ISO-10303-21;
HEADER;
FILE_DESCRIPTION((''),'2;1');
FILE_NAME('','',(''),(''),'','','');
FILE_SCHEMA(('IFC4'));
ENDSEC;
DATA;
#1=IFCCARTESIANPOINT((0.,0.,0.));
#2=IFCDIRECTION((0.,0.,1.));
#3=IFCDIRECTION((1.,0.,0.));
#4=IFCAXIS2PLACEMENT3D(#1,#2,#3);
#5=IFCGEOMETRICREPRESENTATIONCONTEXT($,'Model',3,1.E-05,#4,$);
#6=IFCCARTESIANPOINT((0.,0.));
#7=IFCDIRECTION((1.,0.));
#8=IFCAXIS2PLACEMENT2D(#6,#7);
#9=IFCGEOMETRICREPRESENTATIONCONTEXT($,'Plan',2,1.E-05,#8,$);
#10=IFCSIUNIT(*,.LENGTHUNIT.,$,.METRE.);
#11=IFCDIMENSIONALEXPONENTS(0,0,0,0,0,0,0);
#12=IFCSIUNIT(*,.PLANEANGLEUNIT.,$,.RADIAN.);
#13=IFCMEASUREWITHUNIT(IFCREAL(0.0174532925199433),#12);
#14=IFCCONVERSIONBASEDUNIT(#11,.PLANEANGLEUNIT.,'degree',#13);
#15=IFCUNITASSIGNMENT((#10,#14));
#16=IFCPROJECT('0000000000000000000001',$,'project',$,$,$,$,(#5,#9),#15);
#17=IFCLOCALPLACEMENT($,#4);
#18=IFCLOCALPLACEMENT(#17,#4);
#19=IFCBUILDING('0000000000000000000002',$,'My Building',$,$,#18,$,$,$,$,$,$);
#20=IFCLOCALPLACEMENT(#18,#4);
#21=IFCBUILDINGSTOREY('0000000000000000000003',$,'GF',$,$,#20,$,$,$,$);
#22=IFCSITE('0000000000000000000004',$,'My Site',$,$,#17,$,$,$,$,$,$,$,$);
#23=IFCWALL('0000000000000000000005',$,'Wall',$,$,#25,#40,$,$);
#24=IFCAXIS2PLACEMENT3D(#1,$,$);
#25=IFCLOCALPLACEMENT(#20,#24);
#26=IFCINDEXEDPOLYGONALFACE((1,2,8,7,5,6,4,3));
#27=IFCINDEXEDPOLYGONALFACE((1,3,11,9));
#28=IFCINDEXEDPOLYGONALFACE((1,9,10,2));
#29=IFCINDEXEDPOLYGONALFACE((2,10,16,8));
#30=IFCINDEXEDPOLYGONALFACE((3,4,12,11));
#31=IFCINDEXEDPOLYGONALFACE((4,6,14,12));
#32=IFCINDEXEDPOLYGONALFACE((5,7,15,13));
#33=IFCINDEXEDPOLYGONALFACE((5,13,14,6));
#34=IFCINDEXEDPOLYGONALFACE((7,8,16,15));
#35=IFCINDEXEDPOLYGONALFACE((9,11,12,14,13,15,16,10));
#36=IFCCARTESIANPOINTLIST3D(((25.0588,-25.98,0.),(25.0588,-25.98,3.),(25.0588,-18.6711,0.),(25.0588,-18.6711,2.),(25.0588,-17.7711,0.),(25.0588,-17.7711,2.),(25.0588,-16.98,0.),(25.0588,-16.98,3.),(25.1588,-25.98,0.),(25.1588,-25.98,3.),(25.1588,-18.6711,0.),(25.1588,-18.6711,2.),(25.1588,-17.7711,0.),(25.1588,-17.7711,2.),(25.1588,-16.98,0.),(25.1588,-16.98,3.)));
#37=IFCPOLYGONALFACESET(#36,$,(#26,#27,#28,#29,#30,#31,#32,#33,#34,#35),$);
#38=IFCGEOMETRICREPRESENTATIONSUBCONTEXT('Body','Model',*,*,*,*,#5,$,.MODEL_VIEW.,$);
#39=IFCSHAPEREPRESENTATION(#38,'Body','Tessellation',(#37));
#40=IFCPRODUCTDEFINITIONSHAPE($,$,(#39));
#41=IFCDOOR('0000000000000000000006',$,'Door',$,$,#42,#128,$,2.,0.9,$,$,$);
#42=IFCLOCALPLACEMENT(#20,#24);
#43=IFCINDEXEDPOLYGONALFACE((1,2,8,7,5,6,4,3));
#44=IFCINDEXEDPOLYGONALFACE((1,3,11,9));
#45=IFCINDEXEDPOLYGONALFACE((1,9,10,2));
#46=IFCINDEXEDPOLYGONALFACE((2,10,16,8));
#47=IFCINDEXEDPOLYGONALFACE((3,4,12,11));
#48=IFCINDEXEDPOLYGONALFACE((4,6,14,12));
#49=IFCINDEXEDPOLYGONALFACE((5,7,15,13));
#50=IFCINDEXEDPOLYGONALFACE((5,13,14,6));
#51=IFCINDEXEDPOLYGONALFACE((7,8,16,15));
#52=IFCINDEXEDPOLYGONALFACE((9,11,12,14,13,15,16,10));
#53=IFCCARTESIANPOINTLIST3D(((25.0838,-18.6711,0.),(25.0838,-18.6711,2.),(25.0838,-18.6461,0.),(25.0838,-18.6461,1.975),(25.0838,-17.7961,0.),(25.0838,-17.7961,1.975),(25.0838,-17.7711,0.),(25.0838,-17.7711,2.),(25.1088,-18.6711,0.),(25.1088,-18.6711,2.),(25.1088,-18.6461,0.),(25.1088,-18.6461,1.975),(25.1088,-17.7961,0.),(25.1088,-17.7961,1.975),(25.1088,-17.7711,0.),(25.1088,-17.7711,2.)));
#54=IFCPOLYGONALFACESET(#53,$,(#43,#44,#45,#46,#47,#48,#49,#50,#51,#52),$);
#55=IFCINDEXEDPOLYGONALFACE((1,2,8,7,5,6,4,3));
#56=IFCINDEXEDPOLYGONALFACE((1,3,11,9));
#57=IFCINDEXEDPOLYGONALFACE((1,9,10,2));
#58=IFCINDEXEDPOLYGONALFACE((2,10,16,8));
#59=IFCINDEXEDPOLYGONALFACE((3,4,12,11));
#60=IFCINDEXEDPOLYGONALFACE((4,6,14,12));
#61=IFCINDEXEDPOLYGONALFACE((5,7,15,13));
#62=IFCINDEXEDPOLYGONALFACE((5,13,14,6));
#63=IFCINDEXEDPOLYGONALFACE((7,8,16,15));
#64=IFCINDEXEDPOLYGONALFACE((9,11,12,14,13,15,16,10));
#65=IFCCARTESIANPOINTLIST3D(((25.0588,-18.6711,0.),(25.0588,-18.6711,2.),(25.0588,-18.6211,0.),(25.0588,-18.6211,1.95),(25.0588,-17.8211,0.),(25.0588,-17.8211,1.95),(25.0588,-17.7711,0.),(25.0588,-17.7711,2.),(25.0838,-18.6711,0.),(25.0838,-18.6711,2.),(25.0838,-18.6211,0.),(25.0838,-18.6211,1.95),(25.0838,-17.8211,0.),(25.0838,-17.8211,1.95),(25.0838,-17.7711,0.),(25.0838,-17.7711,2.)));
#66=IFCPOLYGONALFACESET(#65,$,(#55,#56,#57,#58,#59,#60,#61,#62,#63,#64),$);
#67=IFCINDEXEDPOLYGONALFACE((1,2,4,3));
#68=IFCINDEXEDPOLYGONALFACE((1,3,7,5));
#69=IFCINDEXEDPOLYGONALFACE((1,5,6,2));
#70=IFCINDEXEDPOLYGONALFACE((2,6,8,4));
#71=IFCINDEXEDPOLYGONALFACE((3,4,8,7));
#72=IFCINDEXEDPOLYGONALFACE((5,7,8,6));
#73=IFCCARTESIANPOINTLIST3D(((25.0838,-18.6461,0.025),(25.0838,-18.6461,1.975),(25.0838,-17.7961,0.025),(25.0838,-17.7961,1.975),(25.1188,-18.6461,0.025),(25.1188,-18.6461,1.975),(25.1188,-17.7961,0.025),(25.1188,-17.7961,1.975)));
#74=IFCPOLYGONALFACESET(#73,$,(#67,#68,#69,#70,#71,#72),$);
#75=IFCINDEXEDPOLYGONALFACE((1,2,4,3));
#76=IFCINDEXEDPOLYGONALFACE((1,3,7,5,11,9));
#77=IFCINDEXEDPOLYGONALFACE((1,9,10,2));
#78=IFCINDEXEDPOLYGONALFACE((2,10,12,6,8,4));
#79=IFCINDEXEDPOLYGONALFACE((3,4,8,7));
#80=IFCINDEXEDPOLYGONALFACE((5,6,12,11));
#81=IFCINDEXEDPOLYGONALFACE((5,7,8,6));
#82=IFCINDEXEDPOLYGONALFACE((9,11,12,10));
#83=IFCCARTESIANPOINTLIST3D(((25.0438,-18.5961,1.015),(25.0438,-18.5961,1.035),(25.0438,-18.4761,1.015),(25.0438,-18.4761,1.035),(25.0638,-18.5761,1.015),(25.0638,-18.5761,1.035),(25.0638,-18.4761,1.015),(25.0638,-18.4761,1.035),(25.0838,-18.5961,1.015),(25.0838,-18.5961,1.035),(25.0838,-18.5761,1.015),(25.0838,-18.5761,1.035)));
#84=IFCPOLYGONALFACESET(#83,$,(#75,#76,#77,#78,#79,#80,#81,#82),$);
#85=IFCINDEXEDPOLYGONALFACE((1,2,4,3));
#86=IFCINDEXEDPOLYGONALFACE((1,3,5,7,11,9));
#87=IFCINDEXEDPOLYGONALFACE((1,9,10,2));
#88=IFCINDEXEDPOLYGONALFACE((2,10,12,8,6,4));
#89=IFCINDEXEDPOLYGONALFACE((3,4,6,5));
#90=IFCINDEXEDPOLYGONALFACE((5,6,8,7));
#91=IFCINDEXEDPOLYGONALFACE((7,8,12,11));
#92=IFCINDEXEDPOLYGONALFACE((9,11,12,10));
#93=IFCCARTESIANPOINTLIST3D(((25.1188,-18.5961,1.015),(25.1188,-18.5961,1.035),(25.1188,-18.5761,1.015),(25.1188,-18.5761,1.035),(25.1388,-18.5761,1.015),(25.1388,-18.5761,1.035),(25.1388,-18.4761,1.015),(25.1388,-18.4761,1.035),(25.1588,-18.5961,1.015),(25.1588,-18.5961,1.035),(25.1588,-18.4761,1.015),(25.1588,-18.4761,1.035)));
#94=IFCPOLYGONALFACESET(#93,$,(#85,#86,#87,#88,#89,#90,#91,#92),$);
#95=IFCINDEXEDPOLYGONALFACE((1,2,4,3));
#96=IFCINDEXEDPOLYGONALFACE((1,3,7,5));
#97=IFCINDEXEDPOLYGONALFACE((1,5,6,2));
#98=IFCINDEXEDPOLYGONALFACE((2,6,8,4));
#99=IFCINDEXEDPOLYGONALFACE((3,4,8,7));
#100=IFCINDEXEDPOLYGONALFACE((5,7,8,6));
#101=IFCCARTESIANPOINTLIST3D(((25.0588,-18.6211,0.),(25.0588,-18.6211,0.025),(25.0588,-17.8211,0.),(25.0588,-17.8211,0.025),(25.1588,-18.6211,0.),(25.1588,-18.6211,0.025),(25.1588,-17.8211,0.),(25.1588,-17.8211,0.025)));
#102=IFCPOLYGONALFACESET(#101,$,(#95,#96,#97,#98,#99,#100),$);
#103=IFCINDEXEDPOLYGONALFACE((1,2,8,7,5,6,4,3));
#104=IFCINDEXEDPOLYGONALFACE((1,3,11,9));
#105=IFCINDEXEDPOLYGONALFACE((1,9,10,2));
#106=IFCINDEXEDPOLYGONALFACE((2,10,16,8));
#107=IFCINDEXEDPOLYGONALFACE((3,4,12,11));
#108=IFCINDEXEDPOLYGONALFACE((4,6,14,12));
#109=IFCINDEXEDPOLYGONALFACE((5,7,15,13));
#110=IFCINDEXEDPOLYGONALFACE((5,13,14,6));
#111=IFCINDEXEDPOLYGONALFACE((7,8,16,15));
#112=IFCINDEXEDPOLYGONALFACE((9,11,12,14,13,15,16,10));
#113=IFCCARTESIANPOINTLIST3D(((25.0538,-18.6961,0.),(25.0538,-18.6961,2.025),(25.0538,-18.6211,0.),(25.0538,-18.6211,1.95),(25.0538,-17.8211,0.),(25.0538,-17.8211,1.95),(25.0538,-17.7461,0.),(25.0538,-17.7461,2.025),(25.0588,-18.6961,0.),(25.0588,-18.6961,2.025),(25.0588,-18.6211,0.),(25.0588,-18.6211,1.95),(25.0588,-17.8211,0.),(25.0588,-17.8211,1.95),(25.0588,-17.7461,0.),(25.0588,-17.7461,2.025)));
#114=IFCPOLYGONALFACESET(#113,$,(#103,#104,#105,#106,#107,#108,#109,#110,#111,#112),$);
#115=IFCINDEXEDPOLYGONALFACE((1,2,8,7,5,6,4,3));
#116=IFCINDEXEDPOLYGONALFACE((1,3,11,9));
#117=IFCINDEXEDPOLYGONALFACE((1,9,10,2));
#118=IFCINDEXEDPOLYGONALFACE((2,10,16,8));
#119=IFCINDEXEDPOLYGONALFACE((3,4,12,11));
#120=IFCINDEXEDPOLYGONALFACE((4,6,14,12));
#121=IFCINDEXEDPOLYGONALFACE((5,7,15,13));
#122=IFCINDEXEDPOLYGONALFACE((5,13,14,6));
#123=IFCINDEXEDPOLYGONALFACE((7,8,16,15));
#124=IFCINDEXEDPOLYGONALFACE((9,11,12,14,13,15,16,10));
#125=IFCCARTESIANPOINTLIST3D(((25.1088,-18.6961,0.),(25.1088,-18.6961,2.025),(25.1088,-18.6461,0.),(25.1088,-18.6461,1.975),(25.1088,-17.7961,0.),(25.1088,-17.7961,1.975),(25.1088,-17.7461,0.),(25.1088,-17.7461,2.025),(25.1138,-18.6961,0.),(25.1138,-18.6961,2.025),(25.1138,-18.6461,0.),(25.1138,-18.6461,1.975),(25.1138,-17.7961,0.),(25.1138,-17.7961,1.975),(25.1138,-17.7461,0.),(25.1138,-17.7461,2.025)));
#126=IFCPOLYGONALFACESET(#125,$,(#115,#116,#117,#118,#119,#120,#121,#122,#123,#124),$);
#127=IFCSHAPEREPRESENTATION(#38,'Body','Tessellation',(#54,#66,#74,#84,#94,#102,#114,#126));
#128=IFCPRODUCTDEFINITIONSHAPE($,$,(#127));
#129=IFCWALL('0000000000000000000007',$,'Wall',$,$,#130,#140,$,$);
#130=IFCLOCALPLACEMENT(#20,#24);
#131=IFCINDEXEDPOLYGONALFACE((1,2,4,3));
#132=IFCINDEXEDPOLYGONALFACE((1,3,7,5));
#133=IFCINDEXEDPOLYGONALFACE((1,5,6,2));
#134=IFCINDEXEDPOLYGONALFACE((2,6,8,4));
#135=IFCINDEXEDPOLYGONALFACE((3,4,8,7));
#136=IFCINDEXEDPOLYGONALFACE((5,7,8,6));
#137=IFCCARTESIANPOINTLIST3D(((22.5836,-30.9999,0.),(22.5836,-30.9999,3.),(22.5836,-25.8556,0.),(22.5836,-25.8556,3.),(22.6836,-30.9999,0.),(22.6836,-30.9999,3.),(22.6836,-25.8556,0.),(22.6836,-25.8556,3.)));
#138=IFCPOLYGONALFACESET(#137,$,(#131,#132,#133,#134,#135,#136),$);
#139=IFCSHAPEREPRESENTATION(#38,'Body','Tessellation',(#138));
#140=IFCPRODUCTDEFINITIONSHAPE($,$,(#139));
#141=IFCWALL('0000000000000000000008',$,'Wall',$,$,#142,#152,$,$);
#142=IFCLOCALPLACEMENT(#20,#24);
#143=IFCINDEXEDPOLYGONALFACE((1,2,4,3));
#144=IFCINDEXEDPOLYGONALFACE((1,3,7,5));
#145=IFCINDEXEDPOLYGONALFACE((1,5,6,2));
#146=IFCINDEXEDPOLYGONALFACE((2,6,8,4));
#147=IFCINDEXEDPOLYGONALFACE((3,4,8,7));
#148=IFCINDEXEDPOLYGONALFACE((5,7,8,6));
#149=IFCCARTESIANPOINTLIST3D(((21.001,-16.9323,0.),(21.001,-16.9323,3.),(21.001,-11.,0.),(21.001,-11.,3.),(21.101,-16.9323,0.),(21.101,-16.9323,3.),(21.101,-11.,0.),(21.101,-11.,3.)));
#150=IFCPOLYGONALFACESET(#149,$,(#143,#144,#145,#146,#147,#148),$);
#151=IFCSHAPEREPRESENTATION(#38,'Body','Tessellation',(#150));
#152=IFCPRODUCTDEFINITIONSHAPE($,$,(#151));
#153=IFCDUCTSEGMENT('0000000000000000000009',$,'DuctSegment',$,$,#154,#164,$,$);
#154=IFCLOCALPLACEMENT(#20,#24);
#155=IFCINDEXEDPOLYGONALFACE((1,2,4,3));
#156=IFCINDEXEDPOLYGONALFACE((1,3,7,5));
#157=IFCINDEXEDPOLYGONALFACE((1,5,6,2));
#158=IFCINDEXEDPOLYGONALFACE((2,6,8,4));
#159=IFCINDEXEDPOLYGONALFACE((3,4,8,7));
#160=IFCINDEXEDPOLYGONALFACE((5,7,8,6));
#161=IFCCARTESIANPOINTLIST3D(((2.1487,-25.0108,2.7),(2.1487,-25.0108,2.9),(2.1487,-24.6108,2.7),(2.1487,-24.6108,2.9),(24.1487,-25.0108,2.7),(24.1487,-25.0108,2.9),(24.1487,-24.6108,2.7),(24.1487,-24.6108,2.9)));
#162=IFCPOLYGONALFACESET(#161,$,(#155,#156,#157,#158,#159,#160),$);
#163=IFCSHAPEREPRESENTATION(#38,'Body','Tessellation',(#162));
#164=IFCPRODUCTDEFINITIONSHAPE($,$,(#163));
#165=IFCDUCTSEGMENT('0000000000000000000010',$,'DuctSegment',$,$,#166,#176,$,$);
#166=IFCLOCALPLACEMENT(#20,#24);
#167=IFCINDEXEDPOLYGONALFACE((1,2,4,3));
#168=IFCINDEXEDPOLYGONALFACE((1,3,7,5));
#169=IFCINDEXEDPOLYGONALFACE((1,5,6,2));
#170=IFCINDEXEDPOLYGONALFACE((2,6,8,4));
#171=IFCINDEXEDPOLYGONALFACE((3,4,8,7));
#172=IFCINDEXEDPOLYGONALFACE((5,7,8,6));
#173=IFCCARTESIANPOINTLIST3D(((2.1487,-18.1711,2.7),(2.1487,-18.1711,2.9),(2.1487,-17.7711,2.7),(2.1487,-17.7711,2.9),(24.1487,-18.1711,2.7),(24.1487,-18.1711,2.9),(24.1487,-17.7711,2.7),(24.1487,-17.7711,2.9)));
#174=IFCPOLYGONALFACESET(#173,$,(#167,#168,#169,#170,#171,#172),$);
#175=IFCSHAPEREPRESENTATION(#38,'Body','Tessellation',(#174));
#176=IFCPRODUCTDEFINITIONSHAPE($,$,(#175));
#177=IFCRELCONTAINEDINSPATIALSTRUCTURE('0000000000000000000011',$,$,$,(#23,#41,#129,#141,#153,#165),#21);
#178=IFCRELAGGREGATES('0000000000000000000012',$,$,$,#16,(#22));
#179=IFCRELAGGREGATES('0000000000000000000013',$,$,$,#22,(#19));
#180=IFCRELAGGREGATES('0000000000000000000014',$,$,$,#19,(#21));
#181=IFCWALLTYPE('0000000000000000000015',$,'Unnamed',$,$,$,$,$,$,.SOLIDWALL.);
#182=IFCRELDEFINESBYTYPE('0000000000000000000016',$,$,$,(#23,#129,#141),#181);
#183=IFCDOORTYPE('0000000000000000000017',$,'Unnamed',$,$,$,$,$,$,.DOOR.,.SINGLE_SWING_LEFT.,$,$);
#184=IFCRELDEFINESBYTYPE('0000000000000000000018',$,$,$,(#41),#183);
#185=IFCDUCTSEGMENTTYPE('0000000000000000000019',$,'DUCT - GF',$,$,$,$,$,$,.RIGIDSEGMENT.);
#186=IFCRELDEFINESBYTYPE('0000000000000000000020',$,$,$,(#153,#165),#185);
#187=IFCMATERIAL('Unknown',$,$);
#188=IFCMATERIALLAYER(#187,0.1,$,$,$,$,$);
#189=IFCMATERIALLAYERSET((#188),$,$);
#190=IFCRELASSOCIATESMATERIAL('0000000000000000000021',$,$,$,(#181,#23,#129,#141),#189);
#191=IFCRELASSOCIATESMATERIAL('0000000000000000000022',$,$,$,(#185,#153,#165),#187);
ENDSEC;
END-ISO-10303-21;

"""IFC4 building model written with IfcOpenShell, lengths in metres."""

from ifc_helpers import new_model, entity, si_unit, converted_unit, frame, origin_with_axes, origin_2d_with_axis, place, context, subcontext, project, spatial, line, indexed_curve, rectangle, outline, extrude, shape, source, transform, mapped, material, layer, layer_set, layer_usage, material_profile, profile_set, profile_usage, type_object, type_shapes, element, fill, save


model = new_model("IFC4")

# Units and contexts
model_context = context("Model", 3, precision=1e-05, world=origin_with_axes())
plan_context = context("Plan", 2, precision=1e-05, world=origin_2d_with_axis())
body_context_1 = subcontext(model_context, "Body", "Model", "MODEL_VIEW")
body_context_2 = subcontext(plan_context, "Body", "Plan", "PLAN_VIEW")
ifc_project = project(units=[si_unit("LENGTHUNIT", "METRE"), converted_unit("PLANEANGLEUNIT", "degree", entity("IfcReal", 0.0174532925199433), si_unit("PLANEANGLEUNIT", "RADIAN"), dimensions=[0, 0, 0, 0, 0, 0, 0])], contexts=[model_context, plan_context])

# Site, building, storey
site_placement = place(None, origin_with_axes())
site = spatial("IfcSite", under=ifc_project, at=site_placement, Name="My Site")
building_placement = place(site_placement, origin_with_axes())
building = spatial("IfcBuilding", under=site, at=building_placement, Name="My Building")
storey_placement = place(building_placement, origin_with_axes())
storey = spatial("IfcBuildingStorey", under=building, at=storey_placement, Name="GF")

# Shared definitions
ifc_material = material(Name="Unknown")
ifc_layer = layer(ifc_material, 0.1)
ifc_layer_set = layer_set([ifc_layer])
wall_type = type_object("IfcWallType", Name="Unnamed", PredefinedType="SOLIDWALL", material=ifc_layer_set)

# Shared definitions
shared_shape_1 = source(origin_with_axes(), body_context_1, "Body", "SweptSolid", [
    extrude(outline(indexed_curve([(0.0, 0.0), (0.9, 0.0), (0.9, 2.0), (0.0, 2.0)], segments=[line(1, 2, 3, 4, 1)])), frame((0.0, -0.6, 0.0), z_axis=(0.0, -1.0, 0.0), x_axis=(1.0, 0.0, 0.0)), (0.0, 0.0, -1.0), 1.2),
])
door_type = type_object("IfcDoorType", Name="Unnamed", OperationType="SINGLE_SWING_LEFT", PredefinedType="DOOR")
shared_shape_2 = source(origin_with_axes(), body_context_1, "Body", "SweptSolid", [
    extrude(outline(indexed_curve([(0.0, 0.0), (0.0, 2.0), (0.9, 2.0), (0.9, 0.0), (0.875, 0.0), (0.875, 1.975), (0.025, 1.975), (0.025, 0.0)], segments=[line(1, 2, 3, 4, 5, 6, 7, 8, 1)])), frame((0.0, 0.025, 0.0), z_axis=(0.0, -1.0, 0.0), x_axis=(1.0, 0.0, 0.0)), (0.0, 0.0, -1.0), 0.025),
    extrude(outline(indexed_curve([(0.0, 0.0), (0.0, 2.0), (0.9, 2.0), (0.9, 0.0), (0.85, 0.0), (0.85, 1.95), (0.05, 1.95), (0.05, 0.0)], segments=[line(1, 2, 3, 4, 5, 6, 7, 8, 1)])), frame((0.0, 0.0, 0.0), z_axis=(0.0, -1.0, 0.0), x_axis=(1.0, 0.0, 0.0)), (0.0, 0.0, -1.0), 0.025),
    extrude(outline(indexed_curve([(0.0, 0.0), (0.85, 0.0), (0.85, 0.035), (0.0, 0.035)], segments=[line(1, 2, 3, 4, 1)])), frame((0.025, 0.025, 0.025), z_axis=(0.0, 0.0, 1.0), x_axis=(1.0, 0.0, 0.0)), (0.0, 0.0, 1.0), 1.95),
    extrude(outline(indexed_curve([(0.0, 0.0), (0.0, -0.04), (-0.12, -0.04), (-0.12, -0.02), (-0.02, -0.02), (-0.02, 0.0)], segments=[line(1, 2, 3, 4, 5, 6, 1)])), frame((0.825, 0.025, 1.015), z_axis=(0.0, 0.0, 1.0), x_axis=(1.0, 0.0, 0.0)), (0.0, 0.0, 1.0), 0.02),
    extrude(outline(indexed_curve([(0.0, 0.0), (0.0, 0.04), (-0.12, 0.04), (-0.12, 0.02), (-0.02, 0.02), (-0.02, 0.0)], segments=[line(1, 2, 3, 4, 5, 6, 1)])), frame((0.825, 0.06, 1.015), z_axis=(0.0, 0.0, 1.0), x_axis=(1.0, 0.0, 0.0)), (0.0, 0.0, 1.0), 0.02),
    extrude(outline(indexed_curve([(0.0, 0.0), (0.8, 0.0), (0.8, 0.1), (0.0, 0.1)], segments=[line(1, 2, 3, 4, 1)])), frame((0.05, 0.0, 0.0), z_axis=(0.0, 0.0, 1.0), x_axis=(1.0, 0.0, 0.0)), (0.0, 0.0, 1.0), 0.025),
    extrude(outline(indexed_curve([(0.0, 0.0), (0.0, 2.025), (0.95, 2.025), (0.95, 0.0), (0.875, 0.0), (0.875, 1.95), (0.075, 1.95), (0.075, 0.0)], segments=[line(1, 2, 3, 4, 5, 6, 7, 8, 1)])), frame((-0.025, -0.005, 0.0), z_axis=(0.0, -1.0, 0.0), x_axis=(1.0, 0.0, 0.0)), (0.0, 0.0, -1.0), 0.005),
    extrude(outline(indexed_curve([(0.0, 0.0), (0.0, 2.025), (0.95, 2.025), (0.95, 0.0), (0.9, 0.0), (0.9, 1.975), (0.05, 1.975), (0.05, 0.0)], segments=[line(1, 2, 3, 4, 5, 6, 7, 8, 1)])), frame((-0.025, 0.05, 0.0), z_axis=(0.0, -1.0, 0.0), x_axis=(1.0, 0.0, 0.0)), (0.0, 0.0, -1.0), 0.005),
])
shared_shape_3 = source(origin_with_axes(), body_context_2, "Body", "Curve2D", [
    entity("IfcIndexedPolyCurve", entity("IfcCartesianPointList2D", [[0.0, 0.0], [0.0, 0.05], [0.025, 0.05], [0.025, 0.025], [0.05, 0.025], [0.05, 0.0]]), [entity("IfcLineIndex", [1, 2, 3, 4, 5, 6, 1])]),
    entity("IfcIndexedPolyCurve", entity("IfcCartesianPointList2D", [[0.9, 0.0], [0.9, 0.05], [0.875, 0.05], [0.875, 0.025], [0.85, 0.025], [0.85, 0.0]]), [entity("IfcLineIndex", [1, 2, 3, 4, 5, 6, 1])]),
    entity("IfcTrimmedCurve", entity("IfcEllipse", entity("IfcAxis2Placement2D", entity("IfcCartesianPoint", [0.06, 0.05]), entity("IfcDirection", [1.0, 0.0])), 0.815, 0.85), [entity("IfcCartesianPoint", [0.875, 0.05])], [entity("IfcCartesianPoint", [0.06, 0.9])], True, "CARTESIAN"),
    entity("IfcIndexedPolyCurve", entity("IfcCartesianPointList2D", [[0.025, 0.05], [0.06, 0.05], [0.06, 0.9], [0.025, 0.9]]), [entity("IfcLineIndex", [1, 2, 3, 4, 1])]),
])
type_shapes(door_type, [shared_shape_2, shared_shape_3])

# Wall, opening, door
ifc_layer_usage_1 = layer_usage(ifc_layer_set, "AXIS2", "POSITIVE", 0.0)
wall_1_placement = place(storey_placement, frame((25.0588, -16.98, 0.0), z_axis=(0.0, 0.0, 1.0), x_axis=(0.0, -1.0, 0.0)))
wall_1 = element("IfcWall", 1, at=wall_1_placement, inside=storey, type_object=wall_type, material=ifc_layer_usage_1, Name="Wall", context=body_context_1, shape_type="SweptSolid", body=[
    extrude(outline(indexed_curve([(0.0, 0.0), (0.0, 0.1), (9.0, 0.1), (9.0, 0.0)], segments=[line(1, 2, 3, 4, 1)])), origin_with_axes(), (0.0, 0.0, 1.0), 3.0),
])
opening_1_placement = place(wall_1_placement, frame((0.7911, 0.0, 0.0), z_axis=(0.0, 0.0, 1.0), x_axis=(1.0, 0.0, 0.0)))
opening_1 = element("IfcOpeningElement", 2, at=opening_1_placement, cuts=wall_1, PredefinedType="OPENING", context=body_context_1, shape_type="MappedRepresentation", body=[
    mapped(shared_shape_1, transform((0.0, 0.0, 0.0), x_axis=(1.0, 0.0, 0.0), y_axis=(0.0, 1.0, 0.0), z_axis=(0.0, 0.0, 1.0), scale=1.0)),
])
door_1_placement = place(opening_1_placement, frame((0.0, 0.0, 0.0), z_axis=(0.0, 0.0, 1.0), x_axis=(1.0, 0.0, 0.0)))
door_1 = element("IfcDoor", 3, at=door_1_placement, inside=storey, type_object=door_type, Name="Door", OverallHeight=2.0, OverallWidth=0.9, shapes=[
    shape(body_context_1, "Body", "MappedRepresentation", [mapped(shared_shape_2, transform((0.0, 0.0, 0.0), x_axis=(1.0, 0.0, 0.0), y_axis=(0.0, 1.0, 0.0), z_axis=(0.0, 0.0, 1.0), scale=1.0))]),
    shape(body_context_2, "Body", "MappedRepresentation", [mapped(shared_shape_3, transform((0.0, 0.0, 0.0), x_axis=(1.0, 0.0, 0.0), y_axis=(0.0, 1.0, 0.0), z_axis=(0.0, 0.0, 1.0), scale=1.0))]),
])
fill(opening_1, door_1)

# Walls
ifc_layer_usage_2 = layer_usage(ifc_layer_set, "AXIS2", "POSITIVE", 0.0)
wall_2_placement = place(storey_placement, frame((22.5836, -25.8556, 0.0), z_axis=(0.0, 0.0, 1.0), x_axis=(0.0, -1.0, 0.0)))
element("IfcWall", 4, at=wall_2_placement, inside=storey, type_object=wall_type, material=ifc_layer_usage_2, Name="Wall", context=body_context_1, shape_type="SweptSolid", body=[
    extrude(outline(indexed_curve([(0.0, 0.0), (0.0, 0.1), (5.1443, 0.1), (5.1443, 0.0)], segments=[line(1, 2, 3, 4, 1)])), origin_with_axes(), (0.0, 0.0, 1.0), 3.0),
])
ifc_layer_usage_3 = layer_usage(ifc_layer_set, "AXIS2", "POSITIVE", 0.0)
wall_3_placement = place(storey_placement, frame((21.101, -16.9323, 0.0), z_axis=(0.0, 0.0, 1.0), x_axis=(0.0, 1.0, 0.0)))
element("IfcWall", 5, at=wall_3_placement, inside=storey, type_object=wall_type, material=ifc_layer_usage_3, Name="Wall", context=body_context_1, shape_type="SweptSolid", body=[
    extrude(outline(indexed_curve([(0.0, 0.0), (0.0, 0.1), (5.9323, 0.1), (5.9323, 0.0)], segments=[line(1, 2, 3, 4, 1)])), origin_with_axes(), (0.0, 0.0, 1.0), 3.0),
])

# Duct segments
ifc_material_profile_1 = material_profile(ifc_material, rectangle(XDim=0.4, YDim=0.2))
ifc_profile_set_1 = profile_set([ifc_material_profile_1])
ifc_profile_usage_1 = profile_usage(ifc_profile_set_1, cardinal=5)
duct_segment_type = type_object("IfcDuctSegmentType", Name="DUCT - GF", PredefinedType="RIGIDSEGMENT", material=ifc_profile_set_1)
duct_segment_1_placement = place(storey_placement, frame((24.1487, -24.8108, 2.8), z_axis=(-1.0, 0.0, 0.0), x_axis=(0.0, -1.0, 0.0)))
element("IfcDuctSegment", 6, at=duct_segment_1_placement, inside=storey, type_object=duct_segment_type, material=ifc_profile_usage_1, Name="DuctSegment", context=body_context_1, shape_type="SweptSolid", body=[
    extrude(rectangle(XDim=0.4, YDim=0.2), origin_with_axes(), (0.0, 0.0, 1.0), 22.0),
])
ifc_profile_usage_2 = profile_usage(ifc_profile_set_1, cardinal=5)
duct_segment_2_placement = place(storey_placement, frame((24.1487, -17.9711, 2.8), z_axis=(-1.0, 0.0, 0.0), x_axis=(0.0, -1.0, 0.0)))
element("IfcDuctSegment", 7, at=duct_segment_2_placement, inside=storey, type_object=duct_segment_type, material=ifc_profile_usage_2, Name="DuctSegment", context=body_context_1, shape_type="SweptSolid", body=[
    extrude(rectangle(XDim=0.4, YDim=0.2), origin_with_axes(), (0.0, 0.0, 1.0), 22.0),
])

save(model, "model.ifc")
